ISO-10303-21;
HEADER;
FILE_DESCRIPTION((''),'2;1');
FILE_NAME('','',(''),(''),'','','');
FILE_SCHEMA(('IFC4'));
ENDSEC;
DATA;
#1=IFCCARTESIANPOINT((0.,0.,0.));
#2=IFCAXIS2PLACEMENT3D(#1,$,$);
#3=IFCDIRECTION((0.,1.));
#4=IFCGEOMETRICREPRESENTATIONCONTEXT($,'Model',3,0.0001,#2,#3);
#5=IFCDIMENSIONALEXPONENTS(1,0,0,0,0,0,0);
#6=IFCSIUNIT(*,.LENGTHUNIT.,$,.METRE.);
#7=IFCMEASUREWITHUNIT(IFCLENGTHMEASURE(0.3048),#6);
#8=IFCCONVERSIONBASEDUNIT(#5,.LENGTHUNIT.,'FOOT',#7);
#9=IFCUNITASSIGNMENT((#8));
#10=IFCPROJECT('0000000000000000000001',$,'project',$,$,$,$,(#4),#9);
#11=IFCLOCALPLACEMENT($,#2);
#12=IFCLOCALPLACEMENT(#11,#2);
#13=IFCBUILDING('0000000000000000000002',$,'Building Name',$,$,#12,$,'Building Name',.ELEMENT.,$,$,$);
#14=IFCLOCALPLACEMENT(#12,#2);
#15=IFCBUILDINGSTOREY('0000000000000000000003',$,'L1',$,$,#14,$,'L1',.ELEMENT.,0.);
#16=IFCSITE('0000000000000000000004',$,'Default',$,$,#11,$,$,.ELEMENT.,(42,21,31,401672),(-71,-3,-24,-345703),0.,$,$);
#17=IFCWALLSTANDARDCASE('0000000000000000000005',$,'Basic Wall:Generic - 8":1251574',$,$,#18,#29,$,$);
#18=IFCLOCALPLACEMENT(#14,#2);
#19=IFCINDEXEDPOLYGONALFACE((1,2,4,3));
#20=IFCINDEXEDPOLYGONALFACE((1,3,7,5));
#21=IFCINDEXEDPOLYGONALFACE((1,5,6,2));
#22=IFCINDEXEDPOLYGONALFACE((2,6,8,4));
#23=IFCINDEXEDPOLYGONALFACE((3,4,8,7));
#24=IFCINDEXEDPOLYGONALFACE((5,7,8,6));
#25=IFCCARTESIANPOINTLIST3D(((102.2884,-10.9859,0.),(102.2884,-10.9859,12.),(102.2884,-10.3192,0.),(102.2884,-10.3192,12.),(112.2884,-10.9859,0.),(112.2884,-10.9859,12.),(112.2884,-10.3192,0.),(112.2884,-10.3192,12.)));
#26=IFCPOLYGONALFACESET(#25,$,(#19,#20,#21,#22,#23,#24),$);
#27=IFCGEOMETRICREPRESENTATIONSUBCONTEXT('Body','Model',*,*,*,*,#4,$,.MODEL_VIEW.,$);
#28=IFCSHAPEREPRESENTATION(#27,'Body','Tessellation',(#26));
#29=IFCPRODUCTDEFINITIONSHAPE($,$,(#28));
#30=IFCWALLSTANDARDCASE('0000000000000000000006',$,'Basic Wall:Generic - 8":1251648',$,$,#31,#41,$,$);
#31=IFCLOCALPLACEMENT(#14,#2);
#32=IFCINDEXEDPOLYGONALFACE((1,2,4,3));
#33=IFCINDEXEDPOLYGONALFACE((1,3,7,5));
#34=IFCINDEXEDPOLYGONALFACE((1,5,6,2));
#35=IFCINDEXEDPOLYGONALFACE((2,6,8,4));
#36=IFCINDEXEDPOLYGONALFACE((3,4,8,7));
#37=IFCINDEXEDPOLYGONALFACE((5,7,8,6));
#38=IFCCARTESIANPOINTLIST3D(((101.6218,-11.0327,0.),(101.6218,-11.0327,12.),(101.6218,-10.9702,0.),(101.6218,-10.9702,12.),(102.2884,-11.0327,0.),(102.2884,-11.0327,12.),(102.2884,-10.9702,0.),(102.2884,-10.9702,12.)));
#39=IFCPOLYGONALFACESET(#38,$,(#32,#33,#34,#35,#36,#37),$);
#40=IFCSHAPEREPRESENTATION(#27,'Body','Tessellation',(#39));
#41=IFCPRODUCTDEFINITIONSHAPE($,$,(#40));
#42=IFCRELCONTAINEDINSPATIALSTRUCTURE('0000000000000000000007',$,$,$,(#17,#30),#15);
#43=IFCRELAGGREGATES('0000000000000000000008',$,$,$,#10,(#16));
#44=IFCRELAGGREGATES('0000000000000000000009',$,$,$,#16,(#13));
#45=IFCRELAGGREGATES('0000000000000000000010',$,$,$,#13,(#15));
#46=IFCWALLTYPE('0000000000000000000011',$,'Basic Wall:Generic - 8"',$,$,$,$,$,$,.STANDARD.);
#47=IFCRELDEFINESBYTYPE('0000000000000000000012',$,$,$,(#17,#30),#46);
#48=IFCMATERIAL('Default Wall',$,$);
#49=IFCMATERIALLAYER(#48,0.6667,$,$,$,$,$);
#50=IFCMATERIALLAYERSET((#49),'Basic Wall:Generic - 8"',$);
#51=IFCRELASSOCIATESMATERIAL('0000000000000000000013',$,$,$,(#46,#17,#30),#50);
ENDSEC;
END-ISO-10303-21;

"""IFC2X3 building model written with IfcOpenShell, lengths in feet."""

from ifc_helpers import new_model, entity, si_unit, converted_unit, direction, frame, frame_2d, origin, place, context, subcontext, project, spatial, rectangle, extrude, material, layer, layer_set, layer_usage, type_object, element, save


model = new_model("IFC2X3")

# Units and contexts
model_context = context("Model", 3, precision=0.0001, world=origin(), true_north=direction((0.0, 1.0)))
body_context = subcontext(model_context, "Body", "Model", "MODEL_VIEW")
ifc_project = project(units=[converted_unit("LENGTHUNIT", "FOOT", entity("IfcLengthMeasure", 0.3048), si_unit("LENGTHUNIT", "METRE"), dimensions=[1, 0, 0, 0, 0, 0, 0])], contexts=[model_context])

# Site, building, storey
site_placement = place(None, origin())
site = spatial("IfcSite", under=ifc_project, at=site_placement, Name="Default", CompositionType="ELEMENT", RefLatitude=(42, 21, 31, 401672), RefLongitude=(-71, -3, -24, -345703), RefElevation=0.0)
building_placement = place(site_placement, origin())
building = spatial("IfcBuilding", under=site, at=building_placement, Name="Building Name", LongName="Building Name", CompositionType="ELEMENT")
storey_placement = place(building_placement, origin())
storey = spatial("IfcBuildingStorey", under=building, at=storey_placement, Name="L1", LongName="L1", CompositionType="ELEMENT", Elevation=0.0)

# Walls
ifc_material_1 = material(Name="Default Wall")
ifc_layer_1 = layer(ifc_material_1, 0.6667)
ifc_layer_set_1 = layer_set([ifc_layer_1], Name="Basic Wall:Generic - 8\"")
wall_type_1 = type_object("IfcWallType", Name="Basic Wall:Generic - 8\"", PredefinedType="STANDARD", material=ifc_layer_set_1)
ifc_layer_usage_1 = layer_usage(ifc_layer_set_1, "AXIS2", "NEGATIVE", 0.3333)
wall_1_placement = place(storey_placement, frame((112.2884, -10.6525, 0.0), z_axis=(0.0, 0.0, 1.0), x_axis=(-1.0, 0.0, 0.0)))
element("IfcWallStandardCase", 1, at=wall_1_placement, inside=storey, type_object=wall_type_1, material=ifc_layer_usage_1, Name="Basic Wall:Generic - 8\":1251574", context=body_context, shape_type="SweptSolid", body=[
    extrude(rectangle(XDim=10.0, YDim=0.6667, at=frame_2d((5.0, 0.0), x_axis=(-1.0, 0.0))), origin(), (0.0, 0.0, 1.0), 12.0),
])
ifc_layer_usage_2 = layer_usage(ifc_layer_set_1, "AXIS2", "NEGATIVE", 0.3333)
wall_2_placement = place(storey_placement, frame((101.9551, -10.9702, 0.0), z_axis=(0.0, 0.0, 1.0), x_axis=(0.0, -1.0, 0.0)))
element("IfcWallStandardCase", 2, at=wall_2_placement, inside=storey, type_object=wall_type_1, material=ifc_layer_usage_2, Name="Basic Wall:Generic - 8\":1251648", context=body_context, shape_type="SweptSolid", body=[
    extrude(rectangle(XDim=0.0625, YDim=0.6667, at=frame_2d((0.0312, 0.0), x_axis=(-1.0, 0.0))), origin(), (0.0, 0.0, 1.0), 12.0),
])

save(model, "model.ifc")
